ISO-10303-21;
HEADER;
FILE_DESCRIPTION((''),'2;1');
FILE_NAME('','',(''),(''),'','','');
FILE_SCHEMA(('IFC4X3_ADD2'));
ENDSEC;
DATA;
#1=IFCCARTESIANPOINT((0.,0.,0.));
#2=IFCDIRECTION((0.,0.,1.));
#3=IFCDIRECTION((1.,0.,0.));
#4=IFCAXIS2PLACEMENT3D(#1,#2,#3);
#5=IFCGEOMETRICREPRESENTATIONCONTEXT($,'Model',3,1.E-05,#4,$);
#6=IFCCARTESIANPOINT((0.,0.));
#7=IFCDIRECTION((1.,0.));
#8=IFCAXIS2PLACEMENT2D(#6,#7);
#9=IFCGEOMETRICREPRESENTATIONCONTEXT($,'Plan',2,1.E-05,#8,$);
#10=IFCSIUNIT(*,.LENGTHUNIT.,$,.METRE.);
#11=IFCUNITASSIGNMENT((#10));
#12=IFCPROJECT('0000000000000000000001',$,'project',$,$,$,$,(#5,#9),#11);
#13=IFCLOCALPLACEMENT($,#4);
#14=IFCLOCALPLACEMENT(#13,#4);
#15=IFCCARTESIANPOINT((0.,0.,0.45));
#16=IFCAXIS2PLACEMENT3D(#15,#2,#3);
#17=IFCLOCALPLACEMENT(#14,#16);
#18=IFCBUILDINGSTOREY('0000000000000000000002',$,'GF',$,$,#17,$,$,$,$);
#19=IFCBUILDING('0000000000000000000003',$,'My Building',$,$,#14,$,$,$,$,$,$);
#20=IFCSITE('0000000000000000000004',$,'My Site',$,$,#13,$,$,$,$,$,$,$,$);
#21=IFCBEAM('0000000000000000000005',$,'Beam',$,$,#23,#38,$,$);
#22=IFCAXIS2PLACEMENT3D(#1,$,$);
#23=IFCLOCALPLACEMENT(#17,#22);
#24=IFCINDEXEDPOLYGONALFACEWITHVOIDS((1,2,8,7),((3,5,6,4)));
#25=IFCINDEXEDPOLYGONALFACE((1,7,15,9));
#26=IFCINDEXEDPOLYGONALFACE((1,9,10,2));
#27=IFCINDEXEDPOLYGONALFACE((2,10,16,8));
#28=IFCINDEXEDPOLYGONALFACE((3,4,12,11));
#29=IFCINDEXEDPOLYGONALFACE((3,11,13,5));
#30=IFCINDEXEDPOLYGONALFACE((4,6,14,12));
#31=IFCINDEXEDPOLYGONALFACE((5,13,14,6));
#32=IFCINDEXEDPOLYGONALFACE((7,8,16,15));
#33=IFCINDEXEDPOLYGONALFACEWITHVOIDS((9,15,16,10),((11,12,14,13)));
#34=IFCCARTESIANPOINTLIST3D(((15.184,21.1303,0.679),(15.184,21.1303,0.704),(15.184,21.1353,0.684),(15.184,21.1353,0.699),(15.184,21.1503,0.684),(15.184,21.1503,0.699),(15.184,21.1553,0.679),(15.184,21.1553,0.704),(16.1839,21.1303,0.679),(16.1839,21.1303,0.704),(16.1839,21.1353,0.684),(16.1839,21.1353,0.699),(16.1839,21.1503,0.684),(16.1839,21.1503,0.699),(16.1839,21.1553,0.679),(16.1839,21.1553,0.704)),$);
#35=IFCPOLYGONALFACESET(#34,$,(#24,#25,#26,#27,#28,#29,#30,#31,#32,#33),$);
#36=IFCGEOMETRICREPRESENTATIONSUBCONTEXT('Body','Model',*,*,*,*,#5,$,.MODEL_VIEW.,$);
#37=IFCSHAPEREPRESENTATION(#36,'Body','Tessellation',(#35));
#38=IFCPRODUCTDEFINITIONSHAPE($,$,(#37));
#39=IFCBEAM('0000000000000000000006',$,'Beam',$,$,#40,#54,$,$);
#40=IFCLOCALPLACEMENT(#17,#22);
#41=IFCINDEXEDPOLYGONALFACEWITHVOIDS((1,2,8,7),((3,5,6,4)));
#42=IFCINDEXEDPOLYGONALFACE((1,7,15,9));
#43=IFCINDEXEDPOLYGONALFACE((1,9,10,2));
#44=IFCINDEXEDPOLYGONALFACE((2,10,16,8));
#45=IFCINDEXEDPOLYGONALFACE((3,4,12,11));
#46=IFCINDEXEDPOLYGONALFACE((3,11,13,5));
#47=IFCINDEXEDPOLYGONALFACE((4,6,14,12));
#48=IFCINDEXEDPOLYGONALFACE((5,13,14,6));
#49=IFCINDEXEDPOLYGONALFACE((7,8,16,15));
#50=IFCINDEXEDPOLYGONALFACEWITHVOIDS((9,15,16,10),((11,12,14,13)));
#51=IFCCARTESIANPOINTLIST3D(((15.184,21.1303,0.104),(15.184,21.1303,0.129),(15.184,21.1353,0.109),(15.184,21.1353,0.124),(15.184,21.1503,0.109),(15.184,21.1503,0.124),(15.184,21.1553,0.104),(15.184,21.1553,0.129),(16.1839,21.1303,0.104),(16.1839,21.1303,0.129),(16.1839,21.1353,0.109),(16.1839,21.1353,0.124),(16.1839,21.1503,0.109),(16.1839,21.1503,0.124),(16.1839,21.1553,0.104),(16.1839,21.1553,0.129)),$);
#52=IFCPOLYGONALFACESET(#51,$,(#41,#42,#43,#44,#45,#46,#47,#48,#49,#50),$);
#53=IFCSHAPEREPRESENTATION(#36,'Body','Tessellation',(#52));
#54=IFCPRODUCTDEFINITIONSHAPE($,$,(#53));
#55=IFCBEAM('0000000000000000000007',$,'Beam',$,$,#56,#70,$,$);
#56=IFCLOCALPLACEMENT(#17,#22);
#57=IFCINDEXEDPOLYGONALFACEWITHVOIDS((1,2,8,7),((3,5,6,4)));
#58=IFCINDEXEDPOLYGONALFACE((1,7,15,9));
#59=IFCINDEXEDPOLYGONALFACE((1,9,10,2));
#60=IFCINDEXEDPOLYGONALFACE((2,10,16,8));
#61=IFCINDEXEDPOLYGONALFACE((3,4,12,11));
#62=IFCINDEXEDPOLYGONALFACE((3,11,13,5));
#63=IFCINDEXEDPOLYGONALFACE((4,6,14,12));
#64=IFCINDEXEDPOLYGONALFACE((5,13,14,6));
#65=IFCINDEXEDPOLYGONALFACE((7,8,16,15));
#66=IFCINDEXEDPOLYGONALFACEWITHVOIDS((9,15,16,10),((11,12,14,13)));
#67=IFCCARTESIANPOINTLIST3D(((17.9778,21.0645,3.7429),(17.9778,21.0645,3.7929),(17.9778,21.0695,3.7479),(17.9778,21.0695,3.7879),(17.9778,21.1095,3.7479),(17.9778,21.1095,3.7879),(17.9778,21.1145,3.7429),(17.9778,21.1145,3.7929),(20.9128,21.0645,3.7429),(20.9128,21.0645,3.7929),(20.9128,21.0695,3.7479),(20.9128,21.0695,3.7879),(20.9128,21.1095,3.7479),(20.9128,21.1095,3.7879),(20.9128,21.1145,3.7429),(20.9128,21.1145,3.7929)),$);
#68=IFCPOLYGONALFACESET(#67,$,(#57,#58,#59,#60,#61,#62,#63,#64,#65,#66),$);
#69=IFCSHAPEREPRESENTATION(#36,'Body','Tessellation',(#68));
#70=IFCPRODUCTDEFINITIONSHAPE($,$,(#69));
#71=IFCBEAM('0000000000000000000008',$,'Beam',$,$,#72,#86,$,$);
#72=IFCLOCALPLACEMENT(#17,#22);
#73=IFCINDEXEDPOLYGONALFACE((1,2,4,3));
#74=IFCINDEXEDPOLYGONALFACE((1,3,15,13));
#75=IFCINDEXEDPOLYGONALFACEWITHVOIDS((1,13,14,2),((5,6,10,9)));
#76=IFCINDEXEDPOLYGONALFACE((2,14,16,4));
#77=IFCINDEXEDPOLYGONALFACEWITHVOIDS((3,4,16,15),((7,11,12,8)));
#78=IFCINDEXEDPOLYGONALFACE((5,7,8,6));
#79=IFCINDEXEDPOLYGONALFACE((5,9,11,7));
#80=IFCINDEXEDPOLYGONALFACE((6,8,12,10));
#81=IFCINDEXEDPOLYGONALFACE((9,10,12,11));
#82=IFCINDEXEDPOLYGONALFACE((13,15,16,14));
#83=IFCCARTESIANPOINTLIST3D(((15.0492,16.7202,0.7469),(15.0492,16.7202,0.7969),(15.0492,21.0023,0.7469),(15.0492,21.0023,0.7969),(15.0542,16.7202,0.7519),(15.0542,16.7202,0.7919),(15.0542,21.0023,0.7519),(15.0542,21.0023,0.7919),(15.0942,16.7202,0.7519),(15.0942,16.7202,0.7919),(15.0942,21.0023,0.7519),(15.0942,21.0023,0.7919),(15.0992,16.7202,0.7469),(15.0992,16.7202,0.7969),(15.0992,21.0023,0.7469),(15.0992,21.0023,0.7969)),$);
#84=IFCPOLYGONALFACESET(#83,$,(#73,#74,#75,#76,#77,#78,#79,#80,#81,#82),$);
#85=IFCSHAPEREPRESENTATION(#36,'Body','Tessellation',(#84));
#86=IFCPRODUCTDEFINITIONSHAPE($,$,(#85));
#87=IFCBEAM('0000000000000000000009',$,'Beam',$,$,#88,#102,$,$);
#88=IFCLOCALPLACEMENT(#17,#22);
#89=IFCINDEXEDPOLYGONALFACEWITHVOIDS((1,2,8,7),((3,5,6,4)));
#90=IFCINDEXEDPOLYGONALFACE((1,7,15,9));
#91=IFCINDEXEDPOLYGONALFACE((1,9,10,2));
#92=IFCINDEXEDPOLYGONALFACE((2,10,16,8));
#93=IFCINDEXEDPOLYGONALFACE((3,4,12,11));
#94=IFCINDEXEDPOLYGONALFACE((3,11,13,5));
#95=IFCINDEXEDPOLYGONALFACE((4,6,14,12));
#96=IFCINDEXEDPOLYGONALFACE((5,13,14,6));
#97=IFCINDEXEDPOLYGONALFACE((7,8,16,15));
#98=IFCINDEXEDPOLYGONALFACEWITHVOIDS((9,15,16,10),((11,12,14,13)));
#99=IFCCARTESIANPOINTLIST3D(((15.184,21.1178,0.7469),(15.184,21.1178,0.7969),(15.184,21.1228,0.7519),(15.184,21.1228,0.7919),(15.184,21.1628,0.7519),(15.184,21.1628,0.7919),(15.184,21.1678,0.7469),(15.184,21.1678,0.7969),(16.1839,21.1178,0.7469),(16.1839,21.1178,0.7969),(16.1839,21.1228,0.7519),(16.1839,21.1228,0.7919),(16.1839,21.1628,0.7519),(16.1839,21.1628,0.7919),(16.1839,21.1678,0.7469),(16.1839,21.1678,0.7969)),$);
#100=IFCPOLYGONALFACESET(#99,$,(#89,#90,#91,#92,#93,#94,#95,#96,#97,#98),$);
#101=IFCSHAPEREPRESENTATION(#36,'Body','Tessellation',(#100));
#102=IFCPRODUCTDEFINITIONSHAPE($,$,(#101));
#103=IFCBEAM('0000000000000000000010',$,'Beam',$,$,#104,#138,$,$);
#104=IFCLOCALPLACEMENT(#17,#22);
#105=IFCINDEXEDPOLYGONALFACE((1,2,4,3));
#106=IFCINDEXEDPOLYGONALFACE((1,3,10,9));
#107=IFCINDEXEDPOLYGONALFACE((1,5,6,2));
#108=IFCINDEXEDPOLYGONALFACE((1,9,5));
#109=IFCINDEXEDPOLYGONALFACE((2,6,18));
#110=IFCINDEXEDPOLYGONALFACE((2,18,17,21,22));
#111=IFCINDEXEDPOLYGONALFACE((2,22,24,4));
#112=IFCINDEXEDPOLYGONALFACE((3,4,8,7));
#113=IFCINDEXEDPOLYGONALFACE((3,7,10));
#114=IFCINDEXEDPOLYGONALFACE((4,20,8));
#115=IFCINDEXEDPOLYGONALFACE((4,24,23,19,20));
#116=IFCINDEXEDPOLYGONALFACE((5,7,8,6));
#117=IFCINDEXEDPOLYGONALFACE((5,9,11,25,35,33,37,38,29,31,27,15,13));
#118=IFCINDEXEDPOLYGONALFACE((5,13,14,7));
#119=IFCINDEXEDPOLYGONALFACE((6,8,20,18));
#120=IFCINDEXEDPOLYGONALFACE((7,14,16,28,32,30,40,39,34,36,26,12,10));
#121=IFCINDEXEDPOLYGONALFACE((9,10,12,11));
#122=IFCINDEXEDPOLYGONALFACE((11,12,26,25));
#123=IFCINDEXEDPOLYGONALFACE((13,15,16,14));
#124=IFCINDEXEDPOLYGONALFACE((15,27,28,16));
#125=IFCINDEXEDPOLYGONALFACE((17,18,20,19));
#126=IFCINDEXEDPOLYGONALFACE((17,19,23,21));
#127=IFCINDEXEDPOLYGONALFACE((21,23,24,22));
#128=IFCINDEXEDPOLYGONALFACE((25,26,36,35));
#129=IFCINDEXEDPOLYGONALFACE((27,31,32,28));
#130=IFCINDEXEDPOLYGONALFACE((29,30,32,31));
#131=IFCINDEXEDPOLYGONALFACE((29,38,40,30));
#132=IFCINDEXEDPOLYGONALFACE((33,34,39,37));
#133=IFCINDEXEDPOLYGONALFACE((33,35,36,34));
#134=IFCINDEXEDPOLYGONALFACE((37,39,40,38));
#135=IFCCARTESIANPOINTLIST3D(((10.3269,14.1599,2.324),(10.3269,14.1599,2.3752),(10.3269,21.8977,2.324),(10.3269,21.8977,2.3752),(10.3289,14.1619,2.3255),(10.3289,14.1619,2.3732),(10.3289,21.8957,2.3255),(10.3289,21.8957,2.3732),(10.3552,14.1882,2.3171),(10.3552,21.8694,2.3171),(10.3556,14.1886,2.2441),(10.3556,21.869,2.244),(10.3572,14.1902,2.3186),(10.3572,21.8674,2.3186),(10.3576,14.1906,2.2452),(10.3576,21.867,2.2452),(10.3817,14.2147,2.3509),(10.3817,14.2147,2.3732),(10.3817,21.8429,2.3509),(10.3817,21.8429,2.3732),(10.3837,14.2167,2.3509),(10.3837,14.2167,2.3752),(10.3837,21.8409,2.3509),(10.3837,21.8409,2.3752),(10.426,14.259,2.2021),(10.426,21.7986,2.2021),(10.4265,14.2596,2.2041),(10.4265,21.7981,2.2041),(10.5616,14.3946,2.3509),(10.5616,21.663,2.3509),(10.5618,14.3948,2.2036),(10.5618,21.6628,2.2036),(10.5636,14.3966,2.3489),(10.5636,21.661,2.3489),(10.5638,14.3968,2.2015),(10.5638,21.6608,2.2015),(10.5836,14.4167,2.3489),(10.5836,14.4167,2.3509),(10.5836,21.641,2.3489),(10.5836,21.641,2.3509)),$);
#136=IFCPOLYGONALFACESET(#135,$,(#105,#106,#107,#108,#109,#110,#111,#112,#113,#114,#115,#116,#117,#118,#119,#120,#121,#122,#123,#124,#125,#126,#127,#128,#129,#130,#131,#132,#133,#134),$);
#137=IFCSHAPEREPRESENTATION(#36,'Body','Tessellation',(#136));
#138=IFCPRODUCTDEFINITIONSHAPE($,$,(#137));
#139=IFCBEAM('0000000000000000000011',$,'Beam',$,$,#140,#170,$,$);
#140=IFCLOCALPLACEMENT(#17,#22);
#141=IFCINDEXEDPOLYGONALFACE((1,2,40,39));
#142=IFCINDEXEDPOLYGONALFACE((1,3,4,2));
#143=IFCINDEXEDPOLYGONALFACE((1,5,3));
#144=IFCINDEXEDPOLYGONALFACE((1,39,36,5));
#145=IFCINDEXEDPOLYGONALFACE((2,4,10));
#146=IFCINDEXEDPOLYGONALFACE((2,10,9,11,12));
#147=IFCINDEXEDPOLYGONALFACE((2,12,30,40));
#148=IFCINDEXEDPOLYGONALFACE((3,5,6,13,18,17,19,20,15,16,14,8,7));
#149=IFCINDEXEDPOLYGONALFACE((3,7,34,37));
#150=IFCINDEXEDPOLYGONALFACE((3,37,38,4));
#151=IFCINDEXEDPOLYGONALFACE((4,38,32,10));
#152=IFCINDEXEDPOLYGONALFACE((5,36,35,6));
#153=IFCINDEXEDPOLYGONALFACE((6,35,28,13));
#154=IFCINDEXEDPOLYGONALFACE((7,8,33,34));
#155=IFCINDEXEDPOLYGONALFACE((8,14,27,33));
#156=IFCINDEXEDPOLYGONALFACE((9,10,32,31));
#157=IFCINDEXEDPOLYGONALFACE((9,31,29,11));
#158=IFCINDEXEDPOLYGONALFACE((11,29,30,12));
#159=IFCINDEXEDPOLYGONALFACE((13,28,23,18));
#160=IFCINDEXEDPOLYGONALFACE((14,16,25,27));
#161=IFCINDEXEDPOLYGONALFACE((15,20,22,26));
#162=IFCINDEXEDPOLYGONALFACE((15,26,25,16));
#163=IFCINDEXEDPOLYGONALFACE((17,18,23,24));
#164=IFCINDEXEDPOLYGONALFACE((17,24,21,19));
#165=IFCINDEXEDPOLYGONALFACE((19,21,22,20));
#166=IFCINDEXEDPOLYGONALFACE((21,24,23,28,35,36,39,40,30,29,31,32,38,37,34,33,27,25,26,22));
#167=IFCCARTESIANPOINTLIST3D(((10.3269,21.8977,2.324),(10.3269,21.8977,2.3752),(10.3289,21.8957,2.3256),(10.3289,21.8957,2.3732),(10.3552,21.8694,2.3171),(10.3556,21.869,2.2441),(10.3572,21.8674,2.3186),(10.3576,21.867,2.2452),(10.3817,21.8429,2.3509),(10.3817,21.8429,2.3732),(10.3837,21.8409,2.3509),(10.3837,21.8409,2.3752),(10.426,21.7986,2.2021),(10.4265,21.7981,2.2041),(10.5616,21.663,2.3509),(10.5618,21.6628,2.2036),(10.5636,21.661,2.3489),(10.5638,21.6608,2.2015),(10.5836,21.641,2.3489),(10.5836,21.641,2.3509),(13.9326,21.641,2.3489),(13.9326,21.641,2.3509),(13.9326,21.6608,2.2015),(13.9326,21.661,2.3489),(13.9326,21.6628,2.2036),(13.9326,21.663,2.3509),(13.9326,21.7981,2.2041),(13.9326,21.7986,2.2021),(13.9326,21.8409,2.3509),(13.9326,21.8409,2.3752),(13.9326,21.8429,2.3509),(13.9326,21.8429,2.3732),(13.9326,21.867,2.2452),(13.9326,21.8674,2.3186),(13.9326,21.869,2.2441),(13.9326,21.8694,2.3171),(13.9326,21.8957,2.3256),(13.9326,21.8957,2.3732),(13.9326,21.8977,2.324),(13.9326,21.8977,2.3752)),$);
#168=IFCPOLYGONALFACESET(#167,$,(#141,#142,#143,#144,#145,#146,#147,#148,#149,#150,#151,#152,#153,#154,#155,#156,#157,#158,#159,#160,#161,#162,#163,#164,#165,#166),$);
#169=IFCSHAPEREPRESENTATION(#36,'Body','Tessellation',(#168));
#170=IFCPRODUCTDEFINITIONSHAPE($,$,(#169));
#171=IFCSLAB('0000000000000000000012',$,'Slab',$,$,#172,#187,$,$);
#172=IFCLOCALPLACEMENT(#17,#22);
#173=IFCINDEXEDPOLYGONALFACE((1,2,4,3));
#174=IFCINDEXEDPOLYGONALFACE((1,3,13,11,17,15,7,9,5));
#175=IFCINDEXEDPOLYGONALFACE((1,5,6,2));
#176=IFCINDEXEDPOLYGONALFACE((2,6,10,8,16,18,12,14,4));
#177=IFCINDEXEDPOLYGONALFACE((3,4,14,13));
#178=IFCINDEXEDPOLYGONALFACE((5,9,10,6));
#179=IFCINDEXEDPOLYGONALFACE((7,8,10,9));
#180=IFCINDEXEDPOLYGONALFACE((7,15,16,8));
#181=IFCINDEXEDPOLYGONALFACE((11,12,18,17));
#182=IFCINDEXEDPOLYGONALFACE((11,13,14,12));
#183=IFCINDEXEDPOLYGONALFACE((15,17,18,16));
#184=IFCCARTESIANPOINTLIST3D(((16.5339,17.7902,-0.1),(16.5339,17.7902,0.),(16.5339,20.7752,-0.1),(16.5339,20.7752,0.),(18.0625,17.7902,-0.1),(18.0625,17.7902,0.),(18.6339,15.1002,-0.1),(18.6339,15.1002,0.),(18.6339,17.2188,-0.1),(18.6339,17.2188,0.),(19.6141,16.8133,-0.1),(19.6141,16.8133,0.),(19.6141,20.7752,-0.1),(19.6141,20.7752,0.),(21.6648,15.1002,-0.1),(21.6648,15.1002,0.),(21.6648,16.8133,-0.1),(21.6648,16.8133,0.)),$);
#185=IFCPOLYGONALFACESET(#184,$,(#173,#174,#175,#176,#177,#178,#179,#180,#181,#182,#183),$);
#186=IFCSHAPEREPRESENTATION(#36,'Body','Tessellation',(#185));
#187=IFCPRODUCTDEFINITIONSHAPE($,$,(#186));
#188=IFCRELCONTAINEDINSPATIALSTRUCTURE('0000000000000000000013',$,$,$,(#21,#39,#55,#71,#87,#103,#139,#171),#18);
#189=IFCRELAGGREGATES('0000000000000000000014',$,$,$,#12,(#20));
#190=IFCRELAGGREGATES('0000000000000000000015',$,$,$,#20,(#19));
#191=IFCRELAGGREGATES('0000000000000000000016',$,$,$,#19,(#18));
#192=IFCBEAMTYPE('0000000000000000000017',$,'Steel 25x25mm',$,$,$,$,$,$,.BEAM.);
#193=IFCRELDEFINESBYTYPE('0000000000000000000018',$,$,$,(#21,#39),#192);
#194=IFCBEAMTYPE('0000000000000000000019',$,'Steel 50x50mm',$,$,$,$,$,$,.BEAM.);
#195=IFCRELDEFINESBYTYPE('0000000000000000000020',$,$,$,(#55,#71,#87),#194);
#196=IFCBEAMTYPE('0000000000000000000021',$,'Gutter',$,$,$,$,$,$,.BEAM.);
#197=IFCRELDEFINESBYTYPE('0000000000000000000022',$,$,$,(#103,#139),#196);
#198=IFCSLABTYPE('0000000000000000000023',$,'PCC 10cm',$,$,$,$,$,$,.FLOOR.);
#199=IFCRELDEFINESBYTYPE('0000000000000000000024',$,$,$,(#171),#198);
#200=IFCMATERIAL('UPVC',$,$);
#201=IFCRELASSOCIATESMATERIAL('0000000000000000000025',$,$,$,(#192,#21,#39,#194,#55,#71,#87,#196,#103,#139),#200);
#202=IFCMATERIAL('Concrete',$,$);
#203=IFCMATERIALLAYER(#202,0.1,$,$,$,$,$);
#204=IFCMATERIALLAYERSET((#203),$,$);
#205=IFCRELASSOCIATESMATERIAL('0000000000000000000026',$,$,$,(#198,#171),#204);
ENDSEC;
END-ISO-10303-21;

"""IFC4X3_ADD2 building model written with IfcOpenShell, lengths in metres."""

from ifc_helpers import new_model, si_unit, frame, origin_with_axes, origin_2d_with_axis, place, context, subcontext, project, spatial, indexed_curve, hollow_rectangle, outline, extrude, clip, halfspace, material, layer, layer_set, layer_usage, material_profile, profile_set, profile_usage, type_object, element, save


model = new_model("IFC4X3_ADD2")

# Units and contexts
model_context = context("Model", 3, precision=1e-05, world=origin_with_axes())
plan_context = context("Plan", 2, precision=1e-05, world=origin_2d_with_axis())
body_context_1 = subcontext(model_context, "Body", "Model", "MODEL_VIEW")
ifc_project = project(units=[si_unit("LENGTHUNIT", "METRE")], contexts=[model_context, plan_context])

# Site, building, storey
site_placement = place(None, origin_with_axes())
site = spatial("IfcSite", under=ifc_project, at=site_placement, Name="My Site")
building_placement = place(site_placement, origin_with_axes())
building = spatial("IfcBuilding", under=site, at=building_placement, Name="My Building")
storey_placement = place(building_placement, frame((0.0, 0.0, 0.45), z_axis=(0.0, 0.0, 1.0), x_axis=(1.0, 0.0, 0.0)))
storey = spatial("IfcBuildingStorey", under=building, at=storey_placement, Name="GF")

# Shared definitions
ifc_material_1 = material(Name="UPVC")

# Beams
ifc_material_profile_1 = material_profile(ifc_material_1, hollow_rectangle(XDim=0.025, YDim=0.025, WallThickness=0.005))
ifc_profile_set_1 = profile_set([ifc_material_profile_1])
beam_type_1 = type_object("IfcBeamType", Name="Steel 25x25mm", PredefinedType="BEAM", material=ifc_profile_set_1)
ifc_profile_usage_1 = profile_usage(ifc_profile_set_1)
beam_1_placement = place(storey_placement, frame((15.184, 21.1428, 0.6915), z_axis=(1.0, 0.0, 0.0), x_axis=(0.0, 1.0, 0.0)))
element("IfcBeam", 1, at=beam_1_placement, inside=storey, type_object=beam_type_1, material=ifc_profile_usage_1, Name="Beam", context=body_context_1, shape_type="SweptSolid", body=[
    extrude(hollow_rectangle(XDim=0.025, YDim=0.025, WallThickness=0.005), origin_with_axes(), (0.0, 0.0, 1.0), 1.0),
])
ifc_profile_usage_2 = profile_usage(ifc_profile_set_1)
beam_2_placement = place(storey_placement, frame((15.184, 21.1428, 0.1165), z_axis=(1.0, 0.0, 0.0), x_axis=(0.0, 1.0, 0.0)))
element("IfcBeam", 2, at=beam_2_placement, inside=storey, type_object=beam_type_1, material=ifc_profile_usage_2, Name="Beam", context=body_context_1, shape_type="SweptSolid", body=[
    extrude(hollow_rectangle(XDim=0.025, YDim=0.025, WallThickness=0.005), origin_with_axes(), (0.0, 0.0, 1.0), 1.0),
])
ifc_material_profile_2 = material_profile(ifc_material_1, hollow_rectangle(XDim=0.05, YDim=0.05, WallThickness=0.005))
ifc_profile_set_2 = profile_set([ifc_material_profile_2])
ifc_profile_usage_3 = profile_usage(ifc_profile_set_2)
beam_type_2 = type_object("IfcBeamType", Name="Steel 50x50mm", PredefinedType="BEAM", material=ifc_profile_set_2)
beam_3_placement = place(storey_placement, frame((17.9778, 21.0895, 3.7679), z_axis=(1.0, 0.0, 0.0), x_axis=(0.0, 1.0, 0.0)))
element("IfcBeam", 3, at=beam_3_placement, inside=storey, type_object=beam_type_2, material=ifc_profile_usage_3, Name="Beam", context=body_context_1, shape_type="SweptSolid", body=[
    extrude(hollow_rectangle(XDim=0.05, YDim=0.05, WallThickness=0.005), origin_with_axes(), (0.0, 0.0, 1.0), 2.9351),
])
ifc_profile_usage_4 = profile_usage(ifc_profile_set_2)
beam_4_placement = place(storey_placement, frame((15.0742, 21.0023, 0.7719), z_axis=(0.0, -1.0, 0.0), x_axis=(1.0, 0.0, 0.0)))
element("IfcBeam", 4, at=beam_4_placement, inside=storey, type_object=beam_type_2, material=ifc_profile_usage_4, Name="Beam", context=body_context_1, shape_type="SweptSolid", body=[
    extrude(hollow_rectangle(XDim=0.05, YDim=0.05, WallThickness=0.005), origin_with_axes(), (0.0, 0.0, 1.0), 4.2821),
])
ifc_profile_usage_5 = profile_usage(ifc_profile_set_2)
beam_5_placement = place(storey_placement, frame((15.184, 21.1428, 0.7719), z_axis=(1.0, 0.0, 0.0), x_axis=(0.0, 1.0, 0.0)))
element("IfcBeam", 5, at=beam_5_placement, inside=storey, type_object=beam_type_2, material=ifc_profile_usage_5, Name="Beam", context=body_context_1, shape_type="SweptSolid", body=[
    extrude(hollow_rectangle(XDim=0.05, YDim=0.05, WallThickness=0.005), origin_with_axes(), (0.0, 0.0, 1.0), 1.0),
])
ifc_material_profile_3 = material_profile(ifc_material_1, outline(indexed_curve([(0.0548, 0.1717), (0.002, 0.1717), (0.002, 0.124), (0.0303, 0.1171), (0.0307, 0.0436), (0.0996, 0.0025), (0.2349, 0.002), (0.2347, 0.1494), (0.2567, 0.1494), (0.2567, 0.1474), (0.2367, 0.1474), (0.2369, 0.0), (0.0991, 0.0005), (0.0287, 0.0425), (0.0283, 0.1155), (0.0, 0.1224), (0.0, 0.1737), (0.0568, 0.1737), (0.0568, 0.1494), (0.0548, 0.1494), (0.0548, 0.1717)])))
ifc_profile_set_3 = profile_set([ifc_material_profile_3])
ifc_profile_usage_6 = profile_usage(ifc_profile_set_3)
beam_type_3 = type_object("IfcBeamType", Name="Gutter", PredefinedType="BEAM", material=ifc_profile_set_3)
beam_6_placement = place(storey_placement, frame((10.3269, 21.8977, 2.2015), z_axis=(0.0, -1.0, 0.0), x_axis=(1.0, 0.0, 0.0)))
element("IfcBeam", 6, at=beam_6_placement, inside=storey, type_object=beam_type_3, material=ifc_profile_usage_6, Name="Beam", context=body_context_1, shape_type="Clipping", body=[
    clip(clip(extrude(outline(indexed_curve([(0.0548, 0.1717), (0.002, 0.1717), (0.002, 0.124), (0.0303, 0.1171), (0.0307, 0.0436), (0.0996, 0.0025), (0.2349, 0.002), (0.2347, 0.1494), (0.2567, 0.1494), (0.2567, 0.1474), (0.2367, 0.1474), (0.2369, 0.0), (0.0991, 0.0005), (0.0287, 0.0425), (0.0283, 0.1155), (0.0, 0.1224), (0.0, 0.1737), (0.0568, 0.1737), (0.0568, 0.1494), (0.0548, 0.1494), (0.0548, 0.1717)])), origin_with_axes(), (0.0, 0.0, 1.0), 7.7378), halfspace(frame((0.0, -2.6516, 7.7378), z_axis=(0.707107, 0.0, 0.707106), x_axis=(0.0, -1.0, 0.0)), False)), halfspace(frame((0.0, -2.6516, 0.0), z_axis=(0.707106, 0.0, -0.707107), x_axis=(0.0, -1.0, 0.0)), False)),
])
ifc_profile_usage_7 = profile_usage(ifc_profile_set_3)
beam_7_placement = place(storey_placement, frame((13.9326, 21.8977, 2.2015), z_axis=(-1.0, 0.000001, 0.0), x_axis=(-0.000001, -1.0, 0.0)))
element("IfcBeam", 7, at=beam_7_placement, inside=storey, type_object=beam_type_3, material=ifc_profile_usage_7, Name="Beam", context=body_context_1, shape_type="Clipping", body=[
    clip(extrude(outline(indexed_curve([(0.0548, 0.1717), (0.002, 0.1717), (0.002, 0.124), (0.0303, 0.1171), (0.0307, 0.0436), (0.0996, 0.0025), (0.2349, 0.002), (0.2347, 0.1494), (0.2567, 0.1494), (0.2567, 0.1474), (0.2367, 0.1474), (0.2369, 0.0), (0.0991, 0.0005), (0.0287, 0.0425), (0.0283, 0.1155), (0.0, 0.1224), (0.0, 0.1737), (0.0568, 0.1737), (0.0568, 0.1494), (0.0548, 0.1494), (0.0548, 0.1717)])), origin_with_axes(), (0.0, 0.0, 1.0), 3.6057), halfspace(frame((0.0, -2.3765, 3.6057), z_axis=(0.707107, 0.0, 0.707106), x_axis=(0.0, -1.0, 0.0)), False)),
])

# Slab
ifc_material_2 = material(Name="Concrete")
ifc_layer_1 = layer(ifc_material_2, 0.1)
ifc_layer_set_1 = layer_set([ifc_layer_1])
ifc_layer_usage_1 = layer_usage(ifc_layer_set_1, "AXIS3", "POSITIVE", -0.1)
slab_type_1 = type_object("IfcSlabType", Name="PCC 10cm", PredefinedType="FLOOR", material=ifc_layer_set_1)
slab_1_placement = place(storey_placement, frame((16.5339, 20.7752, 0.0), z_axis=(0.0, 0.0, 1.0), x_axis=(1.0, 0.0, 0.0)))
element("IfcSlab", 8, at=slab_1_placement, inside=storey, type_object=slab_type_1, material=ifc_layer_usage_1, Name="Slab", context=body_context_1, shape_type="SweptSolid", body=[
    extrude(outline(indexed_curve([(0.0, -2.985), (1.5286, -2.985), (2.1, -3.5564), (2.1, -5.675), (5.1308, -5.675), (5.1308, -3.9619), (3.0801, -3.9619), (3.0801, 0.0), (0.0, 0.0), (0.0, -2.985)])), frame((0.0, 0.0, -0.1), z_axis=(0.0, 0.0, 1.0), x_axis=(1.0, 0.0, 0.0)), (0.0, 0.0, 1.0), 0.1),
])

save(model, "model.ifc")
